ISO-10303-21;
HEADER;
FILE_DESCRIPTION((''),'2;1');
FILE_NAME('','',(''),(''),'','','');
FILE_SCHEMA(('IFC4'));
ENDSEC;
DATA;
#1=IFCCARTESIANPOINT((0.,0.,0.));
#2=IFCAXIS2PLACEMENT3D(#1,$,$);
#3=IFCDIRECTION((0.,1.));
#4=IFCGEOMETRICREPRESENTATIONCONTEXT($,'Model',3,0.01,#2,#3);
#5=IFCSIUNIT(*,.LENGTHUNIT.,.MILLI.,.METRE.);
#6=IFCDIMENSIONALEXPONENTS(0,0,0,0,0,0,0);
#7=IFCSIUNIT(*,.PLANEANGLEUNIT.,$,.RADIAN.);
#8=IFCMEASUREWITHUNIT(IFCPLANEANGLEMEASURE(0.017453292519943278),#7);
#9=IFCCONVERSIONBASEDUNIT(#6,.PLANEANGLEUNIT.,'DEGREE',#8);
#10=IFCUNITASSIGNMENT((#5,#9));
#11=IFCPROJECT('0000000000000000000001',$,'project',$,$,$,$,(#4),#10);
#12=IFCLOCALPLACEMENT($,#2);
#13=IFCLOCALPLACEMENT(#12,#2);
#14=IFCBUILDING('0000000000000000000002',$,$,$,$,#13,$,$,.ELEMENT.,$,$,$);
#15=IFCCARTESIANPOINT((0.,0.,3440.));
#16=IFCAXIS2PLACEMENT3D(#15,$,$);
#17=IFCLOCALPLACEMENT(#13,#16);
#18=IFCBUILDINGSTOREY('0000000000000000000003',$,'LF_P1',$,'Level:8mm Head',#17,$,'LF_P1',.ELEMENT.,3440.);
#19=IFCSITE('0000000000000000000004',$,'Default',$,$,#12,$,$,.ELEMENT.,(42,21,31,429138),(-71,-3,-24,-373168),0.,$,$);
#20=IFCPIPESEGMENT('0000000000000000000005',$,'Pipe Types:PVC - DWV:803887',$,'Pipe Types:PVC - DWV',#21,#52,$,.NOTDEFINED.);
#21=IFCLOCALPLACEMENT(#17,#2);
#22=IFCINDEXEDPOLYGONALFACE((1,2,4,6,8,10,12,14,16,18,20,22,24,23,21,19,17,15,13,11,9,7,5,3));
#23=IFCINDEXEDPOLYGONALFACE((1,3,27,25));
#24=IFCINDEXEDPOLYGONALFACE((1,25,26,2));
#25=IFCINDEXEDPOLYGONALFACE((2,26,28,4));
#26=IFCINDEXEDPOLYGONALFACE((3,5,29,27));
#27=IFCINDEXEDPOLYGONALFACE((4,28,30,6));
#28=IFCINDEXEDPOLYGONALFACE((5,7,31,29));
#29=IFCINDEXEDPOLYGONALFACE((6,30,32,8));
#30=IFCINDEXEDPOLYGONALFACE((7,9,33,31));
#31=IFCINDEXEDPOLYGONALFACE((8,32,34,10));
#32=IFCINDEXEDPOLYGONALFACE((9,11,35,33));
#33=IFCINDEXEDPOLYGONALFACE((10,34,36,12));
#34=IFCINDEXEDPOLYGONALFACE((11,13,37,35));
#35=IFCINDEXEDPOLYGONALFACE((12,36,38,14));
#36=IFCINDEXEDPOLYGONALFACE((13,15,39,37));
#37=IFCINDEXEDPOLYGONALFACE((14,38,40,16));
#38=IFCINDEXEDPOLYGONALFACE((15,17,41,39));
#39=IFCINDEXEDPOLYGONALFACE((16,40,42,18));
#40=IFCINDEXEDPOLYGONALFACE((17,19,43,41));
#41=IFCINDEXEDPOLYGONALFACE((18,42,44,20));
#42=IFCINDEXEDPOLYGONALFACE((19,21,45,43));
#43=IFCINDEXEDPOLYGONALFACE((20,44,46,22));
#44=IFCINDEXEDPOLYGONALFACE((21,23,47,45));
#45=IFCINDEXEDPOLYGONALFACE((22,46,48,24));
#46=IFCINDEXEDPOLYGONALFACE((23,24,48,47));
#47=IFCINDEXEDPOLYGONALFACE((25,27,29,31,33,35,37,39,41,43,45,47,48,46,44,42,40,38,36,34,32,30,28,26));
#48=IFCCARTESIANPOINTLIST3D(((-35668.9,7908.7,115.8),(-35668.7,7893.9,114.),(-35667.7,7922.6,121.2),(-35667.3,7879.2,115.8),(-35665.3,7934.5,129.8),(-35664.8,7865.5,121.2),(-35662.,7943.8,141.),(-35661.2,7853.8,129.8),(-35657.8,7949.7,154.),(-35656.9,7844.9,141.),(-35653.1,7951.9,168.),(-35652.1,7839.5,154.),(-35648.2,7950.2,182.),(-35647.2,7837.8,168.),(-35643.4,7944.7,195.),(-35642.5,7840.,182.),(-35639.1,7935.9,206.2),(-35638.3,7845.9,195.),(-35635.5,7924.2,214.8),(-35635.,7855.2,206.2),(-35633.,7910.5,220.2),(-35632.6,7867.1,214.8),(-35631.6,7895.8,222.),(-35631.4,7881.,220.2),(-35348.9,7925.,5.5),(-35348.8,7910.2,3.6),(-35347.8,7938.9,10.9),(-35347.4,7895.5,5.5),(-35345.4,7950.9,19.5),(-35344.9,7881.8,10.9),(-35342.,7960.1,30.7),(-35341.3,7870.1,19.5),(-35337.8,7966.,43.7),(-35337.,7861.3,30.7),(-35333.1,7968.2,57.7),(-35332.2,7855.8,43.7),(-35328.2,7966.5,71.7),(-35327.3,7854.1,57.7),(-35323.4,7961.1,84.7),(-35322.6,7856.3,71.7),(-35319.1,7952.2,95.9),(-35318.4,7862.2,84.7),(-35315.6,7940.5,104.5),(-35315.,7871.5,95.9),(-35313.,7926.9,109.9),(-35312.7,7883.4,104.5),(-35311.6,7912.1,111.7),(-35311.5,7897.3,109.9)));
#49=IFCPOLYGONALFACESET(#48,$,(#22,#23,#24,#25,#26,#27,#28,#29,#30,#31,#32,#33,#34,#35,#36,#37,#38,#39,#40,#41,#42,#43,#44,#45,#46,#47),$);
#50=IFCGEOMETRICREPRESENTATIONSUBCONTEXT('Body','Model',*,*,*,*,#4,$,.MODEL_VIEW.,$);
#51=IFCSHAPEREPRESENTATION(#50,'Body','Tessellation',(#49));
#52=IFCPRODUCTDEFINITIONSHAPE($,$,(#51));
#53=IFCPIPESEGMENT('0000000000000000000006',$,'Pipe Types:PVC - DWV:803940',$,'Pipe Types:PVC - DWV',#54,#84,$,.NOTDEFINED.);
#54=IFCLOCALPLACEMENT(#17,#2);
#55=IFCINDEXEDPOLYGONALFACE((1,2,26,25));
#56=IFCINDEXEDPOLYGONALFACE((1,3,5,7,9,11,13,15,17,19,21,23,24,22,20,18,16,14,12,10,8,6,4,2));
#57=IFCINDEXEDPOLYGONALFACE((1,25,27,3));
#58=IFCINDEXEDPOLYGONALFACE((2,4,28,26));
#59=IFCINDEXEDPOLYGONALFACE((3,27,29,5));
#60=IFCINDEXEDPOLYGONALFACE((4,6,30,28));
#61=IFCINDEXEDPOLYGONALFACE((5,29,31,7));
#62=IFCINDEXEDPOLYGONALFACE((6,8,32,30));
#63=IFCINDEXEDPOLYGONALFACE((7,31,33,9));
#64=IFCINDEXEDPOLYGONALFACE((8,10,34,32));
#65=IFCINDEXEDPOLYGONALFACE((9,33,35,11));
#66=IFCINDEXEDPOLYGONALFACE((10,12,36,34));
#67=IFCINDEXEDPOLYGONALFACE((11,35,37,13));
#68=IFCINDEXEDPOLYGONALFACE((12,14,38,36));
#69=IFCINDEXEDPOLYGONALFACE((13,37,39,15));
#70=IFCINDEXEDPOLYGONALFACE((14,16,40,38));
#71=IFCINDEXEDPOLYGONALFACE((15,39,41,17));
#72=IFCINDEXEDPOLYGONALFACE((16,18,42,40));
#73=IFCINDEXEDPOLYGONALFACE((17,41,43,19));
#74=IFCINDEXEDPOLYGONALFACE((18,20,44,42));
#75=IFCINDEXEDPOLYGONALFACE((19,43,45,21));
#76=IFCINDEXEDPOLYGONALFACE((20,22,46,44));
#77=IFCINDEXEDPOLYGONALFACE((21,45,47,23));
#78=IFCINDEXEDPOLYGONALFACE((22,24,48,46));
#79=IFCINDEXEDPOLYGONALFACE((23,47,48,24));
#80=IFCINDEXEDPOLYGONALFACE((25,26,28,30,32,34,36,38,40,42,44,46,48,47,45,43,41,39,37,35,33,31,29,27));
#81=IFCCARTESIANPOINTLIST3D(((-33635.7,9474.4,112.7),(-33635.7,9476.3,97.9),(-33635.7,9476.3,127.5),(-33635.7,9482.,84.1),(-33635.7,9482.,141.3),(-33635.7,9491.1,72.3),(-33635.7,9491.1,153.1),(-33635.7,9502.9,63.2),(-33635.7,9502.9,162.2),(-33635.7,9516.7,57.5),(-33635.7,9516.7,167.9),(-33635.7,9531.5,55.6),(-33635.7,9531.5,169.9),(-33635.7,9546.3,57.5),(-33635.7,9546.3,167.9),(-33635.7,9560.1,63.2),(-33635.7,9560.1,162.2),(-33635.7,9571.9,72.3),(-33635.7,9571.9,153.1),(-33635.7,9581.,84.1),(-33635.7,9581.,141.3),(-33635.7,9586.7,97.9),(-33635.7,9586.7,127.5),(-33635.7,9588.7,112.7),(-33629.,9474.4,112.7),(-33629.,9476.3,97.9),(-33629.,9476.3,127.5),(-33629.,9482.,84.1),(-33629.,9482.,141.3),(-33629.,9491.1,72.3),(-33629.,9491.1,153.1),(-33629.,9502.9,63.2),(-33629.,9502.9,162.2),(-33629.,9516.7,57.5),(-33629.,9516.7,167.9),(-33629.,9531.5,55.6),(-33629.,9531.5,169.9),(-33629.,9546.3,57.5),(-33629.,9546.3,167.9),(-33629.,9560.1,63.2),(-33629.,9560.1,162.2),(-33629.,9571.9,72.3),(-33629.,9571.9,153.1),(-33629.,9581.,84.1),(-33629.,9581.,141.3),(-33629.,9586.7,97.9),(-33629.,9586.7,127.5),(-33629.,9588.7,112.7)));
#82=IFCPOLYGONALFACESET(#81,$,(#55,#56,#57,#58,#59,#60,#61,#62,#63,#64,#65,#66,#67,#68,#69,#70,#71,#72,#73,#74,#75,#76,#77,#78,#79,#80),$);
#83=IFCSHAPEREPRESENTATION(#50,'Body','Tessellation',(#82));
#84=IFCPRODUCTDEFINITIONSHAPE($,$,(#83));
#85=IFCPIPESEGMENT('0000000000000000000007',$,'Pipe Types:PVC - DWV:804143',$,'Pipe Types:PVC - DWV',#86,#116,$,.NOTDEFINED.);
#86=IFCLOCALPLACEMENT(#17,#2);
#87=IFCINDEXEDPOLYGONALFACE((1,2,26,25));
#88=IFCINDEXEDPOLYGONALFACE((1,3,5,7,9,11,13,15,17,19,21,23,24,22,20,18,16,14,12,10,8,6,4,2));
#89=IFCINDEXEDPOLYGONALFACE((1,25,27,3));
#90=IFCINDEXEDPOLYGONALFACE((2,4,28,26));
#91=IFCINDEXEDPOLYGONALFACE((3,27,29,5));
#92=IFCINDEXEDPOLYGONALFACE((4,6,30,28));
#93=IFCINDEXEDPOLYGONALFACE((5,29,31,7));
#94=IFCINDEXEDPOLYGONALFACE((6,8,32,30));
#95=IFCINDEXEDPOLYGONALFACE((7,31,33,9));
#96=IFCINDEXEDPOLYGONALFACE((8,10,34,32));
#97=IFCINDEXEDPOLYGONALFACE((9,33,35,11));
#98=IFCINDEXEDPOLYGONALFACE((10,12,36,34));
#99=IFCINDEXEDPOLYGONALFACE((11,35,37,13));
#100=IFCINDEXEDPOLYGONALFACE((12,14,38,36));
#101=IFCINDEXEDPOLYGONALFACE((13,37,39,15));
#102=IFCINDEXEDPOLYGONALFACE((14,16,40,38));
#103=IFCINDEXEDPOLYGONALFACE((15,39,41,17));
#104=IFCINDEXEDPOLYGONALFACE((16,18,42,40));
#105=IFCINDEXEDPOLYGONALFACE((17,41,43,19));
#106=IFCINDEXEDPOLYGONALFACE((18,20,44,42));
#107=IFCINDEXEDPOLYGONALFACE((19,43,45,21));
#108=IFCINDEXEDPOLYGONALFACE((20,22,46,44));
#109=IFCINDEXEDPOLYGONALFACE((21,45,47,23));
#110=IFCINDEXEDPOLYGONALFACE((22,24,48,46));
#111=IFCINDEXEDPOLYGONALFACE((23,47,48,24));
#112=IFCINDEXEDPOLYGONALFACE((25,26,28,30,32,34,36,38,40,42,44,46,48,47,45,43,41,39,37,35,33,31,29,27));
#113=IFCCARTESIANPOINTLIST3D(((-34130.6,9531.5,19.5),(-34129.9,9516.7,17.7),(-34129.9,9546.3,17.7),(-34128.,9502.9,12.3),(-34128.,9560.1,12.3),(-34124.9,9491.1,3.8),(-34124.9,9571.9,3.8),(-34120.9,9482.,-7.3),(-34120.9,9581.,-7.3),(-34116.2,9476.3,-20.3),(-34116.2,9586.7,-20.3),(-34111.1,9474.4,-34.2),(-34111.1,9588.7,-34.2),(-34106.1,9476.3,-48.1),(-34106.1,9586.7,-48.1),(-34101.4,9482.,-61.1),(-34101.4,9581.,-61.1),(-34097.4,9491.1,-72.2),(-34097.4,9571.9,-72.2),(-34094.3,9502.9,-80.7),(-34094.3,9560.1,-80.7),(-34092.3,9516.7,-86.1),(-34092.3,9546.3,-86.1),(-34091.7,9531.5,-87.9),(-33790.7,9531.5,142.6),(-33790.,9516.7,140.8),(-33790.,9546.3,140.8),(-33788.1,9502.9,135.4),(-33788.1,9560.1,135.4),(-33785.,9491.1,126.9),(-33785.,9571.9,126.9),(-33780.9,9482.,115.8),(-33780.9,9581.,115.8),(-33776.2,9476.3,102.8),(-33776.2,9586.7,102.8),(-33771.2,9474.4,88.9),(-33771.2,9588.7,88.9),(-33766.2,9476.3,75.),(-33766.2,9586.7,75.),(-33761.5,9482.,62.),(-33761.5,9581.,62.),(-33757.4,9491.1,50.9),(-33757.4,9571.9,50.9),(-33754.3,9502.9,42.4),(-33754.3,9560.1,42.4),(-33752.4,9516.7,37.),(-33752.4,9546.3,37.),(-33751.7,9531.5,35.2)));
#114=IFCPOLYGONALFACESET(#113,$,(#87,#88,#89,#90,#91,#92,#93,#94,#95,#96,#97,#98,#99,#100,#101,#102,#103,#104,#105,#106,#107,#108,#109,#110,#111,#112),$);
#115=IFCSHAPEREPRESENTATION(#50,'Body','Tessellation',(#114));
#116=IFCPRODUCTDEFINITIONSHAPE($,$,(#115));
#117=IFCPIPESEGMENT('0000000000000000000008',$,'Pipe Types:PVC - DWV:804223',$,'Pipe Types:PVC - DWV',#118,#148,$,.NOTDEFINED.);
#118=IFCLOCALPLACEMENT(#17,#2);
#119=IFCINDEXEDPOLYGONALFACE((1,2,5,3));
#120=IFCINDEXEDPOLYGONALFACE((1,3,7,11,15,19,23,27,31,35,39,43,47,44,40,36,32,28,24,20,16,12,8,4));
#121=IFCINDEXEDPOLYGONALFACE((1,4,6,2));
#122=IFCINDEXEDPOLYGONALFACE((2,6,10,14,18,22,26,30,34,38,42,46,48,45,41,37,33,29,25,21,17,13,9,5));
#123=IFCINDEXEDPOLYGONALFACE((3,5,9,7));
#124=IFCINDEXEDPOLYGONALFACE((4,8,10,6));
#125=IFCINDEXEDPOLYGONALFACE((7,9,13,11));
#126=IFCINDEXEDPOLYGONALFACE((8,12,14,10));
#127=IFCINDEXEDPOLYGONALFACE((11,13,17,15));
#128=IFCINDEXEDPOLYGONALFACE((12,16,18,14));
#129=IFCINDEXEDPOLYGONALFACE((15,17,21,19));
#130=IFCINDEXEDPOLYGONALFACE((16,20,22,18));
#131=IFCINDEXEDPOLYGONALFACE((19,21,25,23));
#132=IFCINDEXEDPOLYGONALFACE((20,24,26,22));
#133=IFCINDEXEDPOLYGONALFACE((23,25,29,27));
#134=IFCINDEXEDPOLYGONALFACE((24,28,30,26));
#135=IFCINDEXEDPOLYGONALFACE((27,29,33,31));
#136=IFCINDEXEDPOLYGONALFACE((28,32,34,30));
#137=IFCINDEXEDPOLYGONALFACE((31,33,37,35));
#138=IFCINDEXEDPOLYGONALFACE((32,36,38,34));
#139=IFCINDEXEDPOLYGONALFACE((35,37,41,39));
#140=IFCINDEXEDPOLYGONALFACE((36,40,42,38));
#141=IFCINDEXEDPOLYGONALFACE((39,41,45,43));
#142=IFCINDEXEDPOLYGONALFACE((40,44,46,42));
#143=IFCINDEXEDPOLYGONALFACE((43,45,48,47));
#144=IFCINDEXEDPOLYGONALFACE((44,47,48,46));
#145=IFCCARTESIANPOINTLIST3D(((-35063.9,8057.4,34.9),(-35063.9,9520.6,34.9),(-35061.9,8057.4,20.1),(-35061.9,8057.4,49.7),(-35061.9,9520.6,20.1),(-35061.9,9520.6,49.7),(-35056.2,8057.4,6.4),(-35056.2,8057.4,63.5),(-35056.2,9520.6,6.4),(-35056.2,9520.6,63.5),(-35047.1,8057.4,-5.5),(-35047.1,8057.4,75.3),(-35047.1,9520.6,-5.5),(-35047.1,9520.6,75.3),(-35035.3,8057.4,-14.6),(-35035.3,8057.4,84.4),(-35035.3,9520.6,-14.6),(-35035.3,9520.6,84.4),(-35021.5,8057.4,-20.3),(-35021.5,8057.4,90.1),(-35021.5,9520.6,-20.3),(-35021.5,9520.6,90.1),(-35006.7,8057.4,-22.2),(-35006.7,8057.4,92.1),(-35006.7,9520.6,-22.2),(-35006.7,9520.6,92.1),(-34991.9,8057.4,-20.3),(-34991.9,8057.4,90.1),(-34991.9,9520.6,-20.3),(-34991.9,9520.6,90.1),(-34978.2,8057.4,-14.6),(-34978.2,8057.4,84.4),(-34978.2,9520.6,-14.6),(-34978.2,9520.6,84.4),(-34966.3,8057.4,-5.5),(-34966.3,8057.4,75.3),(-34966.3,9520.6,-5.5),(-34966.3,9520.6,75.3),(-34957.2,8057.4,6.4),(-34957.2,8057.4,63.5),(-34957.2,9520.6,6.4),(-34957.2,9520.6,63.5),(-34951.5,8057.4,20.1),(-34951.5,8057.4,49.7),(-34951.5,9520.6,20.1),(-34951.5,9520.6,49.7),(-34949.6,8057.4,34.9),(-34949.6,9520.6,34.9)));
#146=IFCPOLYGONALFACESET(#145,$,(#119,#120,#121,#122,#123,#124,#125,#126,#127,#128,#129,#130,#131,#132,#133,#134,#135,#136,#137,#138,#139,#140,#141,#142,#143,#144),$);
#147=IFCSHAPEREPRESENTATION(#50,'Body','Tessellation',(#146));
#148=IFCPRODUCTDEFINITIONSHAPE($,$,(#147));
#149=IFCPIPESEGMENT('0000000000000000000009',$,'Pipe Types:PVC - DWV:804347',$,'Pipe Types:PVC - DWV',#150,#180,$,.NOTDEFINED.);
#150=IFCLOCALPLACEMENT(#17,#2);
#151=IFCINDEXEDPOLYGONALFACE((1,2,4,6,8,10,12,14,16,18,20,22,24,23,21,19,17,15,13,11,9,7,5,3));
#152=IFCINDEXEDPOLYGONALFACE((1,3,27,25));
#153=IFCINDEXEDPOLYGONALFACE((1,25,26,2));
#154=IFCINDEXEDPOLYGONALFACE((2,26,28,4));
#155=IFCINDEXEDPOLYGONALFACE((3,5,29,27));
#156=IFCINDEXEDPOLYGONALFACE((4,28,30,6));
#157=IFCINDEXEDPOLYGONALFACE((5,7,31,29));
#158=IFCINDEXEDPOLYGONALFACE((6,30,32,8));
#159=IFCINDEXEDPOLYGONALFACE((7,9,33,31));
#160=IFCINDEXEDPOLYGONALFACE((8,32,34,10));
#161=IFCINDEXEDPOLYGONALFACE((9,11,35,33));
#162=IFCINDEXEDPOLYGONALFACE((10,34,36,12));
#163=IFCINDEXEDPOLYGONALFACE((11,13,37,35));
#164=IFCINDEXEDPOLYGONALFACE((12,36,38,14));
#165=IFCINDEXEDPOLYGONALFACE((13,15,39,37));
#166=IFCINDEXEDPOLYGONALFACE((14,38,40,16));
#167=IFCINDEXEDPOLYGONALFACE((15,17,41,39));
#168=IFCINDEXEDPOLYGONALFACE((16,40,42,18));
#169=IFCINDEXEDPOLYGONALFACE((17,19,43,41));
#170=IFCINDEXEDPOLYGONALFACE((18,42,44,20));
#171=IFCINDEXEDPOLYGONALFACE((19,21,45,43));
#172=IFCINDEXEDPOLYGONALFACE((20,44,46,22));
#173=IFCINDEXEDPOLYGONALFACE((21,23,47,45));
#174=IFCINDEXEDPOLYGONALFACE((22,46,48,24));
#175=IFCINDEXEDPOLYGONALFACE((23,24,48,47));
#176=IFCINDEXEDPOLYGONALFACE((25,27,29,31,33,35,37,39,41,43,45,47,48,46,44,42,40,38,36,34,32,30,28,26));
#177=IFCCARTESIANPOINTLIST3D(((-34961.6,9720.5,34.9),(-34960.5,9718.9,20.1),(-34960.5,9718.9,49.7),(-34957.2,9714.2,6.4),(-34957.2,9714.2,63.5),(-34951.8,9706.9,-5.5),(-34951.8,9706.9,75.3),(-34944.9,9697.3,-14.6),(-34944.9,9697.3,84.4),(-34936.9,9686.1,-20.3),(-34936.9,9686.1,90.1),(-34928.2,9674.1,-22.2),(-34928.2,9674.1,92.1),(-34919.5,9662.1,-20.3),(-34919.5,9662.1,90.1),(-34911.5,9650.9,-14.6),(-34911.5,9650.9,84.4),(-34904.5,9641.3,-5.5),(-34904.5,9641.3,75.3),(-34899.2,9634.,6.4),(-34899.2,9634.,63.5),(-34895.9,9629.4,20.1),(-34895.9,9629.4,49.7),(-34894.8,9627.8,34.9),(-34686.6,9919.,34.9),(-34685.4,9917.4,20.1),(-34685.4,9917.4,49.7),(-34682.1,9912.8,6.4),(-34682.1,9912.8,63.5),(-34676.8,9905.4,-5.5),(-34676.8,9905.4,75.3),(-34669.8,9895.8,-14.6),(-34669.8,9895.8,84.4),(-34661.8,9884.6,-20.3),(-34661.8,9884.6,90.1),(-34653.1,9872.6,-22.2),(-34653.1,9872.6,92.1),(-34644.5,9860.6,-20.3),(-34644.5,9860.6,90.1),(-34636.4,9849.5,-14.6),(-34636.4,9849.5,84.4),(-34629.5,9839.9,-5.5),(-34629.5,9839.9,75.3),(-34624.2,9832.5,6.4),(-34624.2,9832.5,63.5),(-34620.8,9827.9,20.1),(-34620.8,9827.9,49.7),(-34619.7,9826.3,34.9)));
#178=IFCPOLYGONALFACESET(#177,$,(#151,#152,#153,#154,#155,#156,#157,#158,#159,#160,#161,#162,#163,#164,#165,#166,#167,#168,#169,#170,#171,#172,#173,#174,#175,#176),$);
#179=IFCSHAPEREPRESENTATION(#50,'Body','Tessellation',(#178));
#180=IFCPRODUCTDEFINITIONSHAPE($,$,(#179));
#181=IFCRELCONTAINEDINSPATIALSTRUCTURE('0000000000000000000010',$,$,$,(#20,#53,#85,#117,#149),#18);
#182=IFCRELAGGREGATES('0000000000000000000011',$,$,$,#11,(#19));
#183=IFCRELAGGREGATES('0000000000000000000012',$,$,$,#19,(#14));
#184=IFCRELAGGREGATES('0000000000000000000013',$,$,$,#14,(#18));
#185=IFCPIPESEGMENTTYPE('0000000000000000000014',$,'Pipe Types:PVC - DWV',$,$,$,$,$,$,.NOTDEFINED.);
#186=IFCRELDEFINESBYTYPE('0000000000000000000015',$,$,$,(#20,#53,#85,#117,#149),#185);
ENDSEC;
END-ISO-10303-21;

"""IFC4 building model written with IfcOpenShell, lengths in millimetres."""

from ifc_helpers import new_model, entity, si_unit, converted_unit, direction, frame, origin, place, context, subcontext, project, spatial, arc, indexed_curve, outline, extrude, type_object, element, save


model = new_model("IFC4")

# Units and contexts
model_context = context("Model", 3, precision=0.01, world=origin(), true_north=direction((0.0, 1.0)))
body_context = subcontext(model_context, "Body", "Model", "MODEL_VIEW")
ifc_project = project(units=[si_unit("LENGTHUNIT", "METRE", prefix="MILLI"), converted_unit("PLANEANGLEUNIT", "DEGREE", entity("IfcPlaneAngleMeasure", 0.017453292519943278), si_unit("PLANEANGLEUNIT", "RADIAN"), dimensions=[0, 0, 0, 0, 0, 0, 0])], contexts=[model_context])

# Site, building, storey
site_placement = place(None, origin())
site = spatial("IfcSite", under=ifc_project, at=site_placement, Name="Default", CompositionType="ELEMENT", RefLatitude=(42, 21, 31, 429138), RefLongitude=(-71, -3, -24, -373168), RefElevation=0.0)
building_placement = place(site_placement, origin())
building = spatial("IfcBuilding", under=site, at=building_placement, CompositionType="ELEMENT")
storey_placement = place(building_placement, frame((0.0, 0.0, 3440.0)))
storey = spatial("IfcBuildingStorey", under=building, at=storey_placement, Name="LF_P1", ObjectType="Level:8mm Head", LongName="LF_P1", CompositionType="ELEMENT", Elevation=3440.0)

# Pipe segments
pipe_segment_type_1 = type_object("IfcPipeSegmentType", Name="Pipe Types:PVC - DWV", PredefinedType="NOTDEFINED")
pipe_segment_1_placement = place(storey_placement, origin())
element("IfcPipeSegment", 1, at=pipe_segment_1_placement, inside=storey, type_object=pipe_segment_type_1, Name="Pipe Types:PVC - DWV:803887", ObjectType="Pipe Types:PVC - DWV", PredefinedType="NOTDEFINED", context=body_context, shape_type="SweptSolid", body=[
    extrude(outline(indexed_curve([(57.1, 0.0), (40.4, 40.4), (0.0, 57.2), (-40.4, 40.4), (-57.2, 0.0), (-40.4, -40.4), (0.0, -57.2), (40.4, -40.4)], segments=[arc(1, 2, 3), arc(3, 4, 5), arc(5, 6, 7), arc(7, 8, 1)], self_intersect=False)), frame((-35650.2, 7894.8, 168.0), z_axis=(0.944275, 0.048164, -0.325614), x_axis=(0.050941, -0.998702, 0.0)), (0.0, 0.0, 1.0), 338.8),
])
pipe_segment_2_placement = place(storey_placement, origin())
element("IfcPipeSegment", 2, at=pipe_segment_2_placement, inside=storey, type_object=pipe_segment_type_1, Name="Pipe Types:PVC - DWV:803940", ObjectType="Pipe Types:PVC - DWV", PredefinedType="NOTDEFINED", context=body_context, shape_type="SweptSolid", body=[
    extrude(outline(indexed_curve([(57.2, 0.0), (40.4, 40.4), (0.0, 57.2), (-40.4, 40.4), (-57.2, 0.0), (-40.4, -40.4), (0.0, -57.2), (40.4, -40.4)], segments=[arc(1, 2, 3), arc(3, 4, 5), arc(5, 6, 7), arc(7, 8, 1)], self_intersect=False)), frame((-33635.7, 9531.5, 112.7), z_axis=(1.0, 0.0, 0.0), x_axis=(0.0, 1.0, 0.0)), (0.0, 0.0, 1.0), 6.7),
])
pipe_segment_3_placement = place(storey_placement, origin())
element("IfcPipeSegment", 3, at=pipe_segment_3_placement, inside=storey, type_object=pipe_segment_type_1, Name="Pipe Types:PVC - DWV:804143", ObjectType="Pipe Types:PVC - DWV", PredefinedType="NOTDEFINED", context=body_context, shape_type="SweptSolid", body=[
    extrude(outline(indexed_curve([(57.2, 0.0), (40.4, 40.4), (0.0, 57.2), (-40.4, 40.4), (-57.2, 0.0), (-40.4, -40.4), (0.0, -57.2), (40.4, -40.4)], segments=[arc(1, 2, 3), arc(3, 4, 5), arc(5, 6, 7), arc(7, 8, 1)], self_intersect=False)), frame((-34111.1, 9531.5, -34.2), z_axis=(0.940234, 0.0, 0.34053), x_axis=(0.0, -1.0, 0.0)), (0.0, 0.0, 1.0), 361.5),
])
pipe_segment_4_placement = place(storey_placement, origin())
element("IfcPipeSegment", 4, at=pipe_segment_4_placement, inside=storey, type_object=pipe_segment_type_1, Name="Pipe Types:PVC - DWV:804223", ObjectType="Pipe Types:PVC - DWV", PredefinedType="NOTDEFINED", context=body_context, shape_type="SweptSolid", body=[
    extrude(outline(indexed_curve([(57.2, 0.0), (40.4, 40.4), (0.0, 57.2), (-40.4, 40.4), (-57.2, 0.0), (-40.4, -40.4), (0.0, -57.2), (40.4, -40.4)], segments=[arc(1, 2, 3), arc(3, 4, 5), arc(5, 6, 7), arc(7, 8, 1)], self_intersect=False)), frame((-35006.7, 8057.4, 34.9), z_axis=(0.0, 1.0, 0.0), x_axis=(1.0, 0.0, 0.0)), (0.0, 0.0, 1.0), 1463.2),
])
pipe_segment_5_placement = place(storey_placement, origin())
element("IfcPipeSegment", 5, at=pipe_segment_5_placement, inside=storey, type_object=pipe_segment_type_1, Name="Pipe Types:PVC - DWV:804347", ObjectType="Pipe Types:PVC - DWV", PredefinedType="NOTDEFINED", context=body_context, shape_type="SweptSolid", body=[
    extrude(outline(indexed_curve([(57.2, 0.0), (40.4, 40.4), (0.0, 57.2), (-40.4, 40.4), (-57.2, 0.0), (-40.4, -40.4), (0.0, -57.2), (40.4, -40.4)], segments=[arc(1, 2, 3), arc(3, 4, 5), arc(5, 6, 7), arc(7, 8, 1)], self_intersect=False)), frame((-34928.2, 9674.1, 34.9), z_axis=(0.810892, 0.585196, 0.0), x_axis=(0.585196, -0.810892, 0.0)), (0.0, 0.0, 1.0), 339.2),
])

save(model, "model.ifc")
